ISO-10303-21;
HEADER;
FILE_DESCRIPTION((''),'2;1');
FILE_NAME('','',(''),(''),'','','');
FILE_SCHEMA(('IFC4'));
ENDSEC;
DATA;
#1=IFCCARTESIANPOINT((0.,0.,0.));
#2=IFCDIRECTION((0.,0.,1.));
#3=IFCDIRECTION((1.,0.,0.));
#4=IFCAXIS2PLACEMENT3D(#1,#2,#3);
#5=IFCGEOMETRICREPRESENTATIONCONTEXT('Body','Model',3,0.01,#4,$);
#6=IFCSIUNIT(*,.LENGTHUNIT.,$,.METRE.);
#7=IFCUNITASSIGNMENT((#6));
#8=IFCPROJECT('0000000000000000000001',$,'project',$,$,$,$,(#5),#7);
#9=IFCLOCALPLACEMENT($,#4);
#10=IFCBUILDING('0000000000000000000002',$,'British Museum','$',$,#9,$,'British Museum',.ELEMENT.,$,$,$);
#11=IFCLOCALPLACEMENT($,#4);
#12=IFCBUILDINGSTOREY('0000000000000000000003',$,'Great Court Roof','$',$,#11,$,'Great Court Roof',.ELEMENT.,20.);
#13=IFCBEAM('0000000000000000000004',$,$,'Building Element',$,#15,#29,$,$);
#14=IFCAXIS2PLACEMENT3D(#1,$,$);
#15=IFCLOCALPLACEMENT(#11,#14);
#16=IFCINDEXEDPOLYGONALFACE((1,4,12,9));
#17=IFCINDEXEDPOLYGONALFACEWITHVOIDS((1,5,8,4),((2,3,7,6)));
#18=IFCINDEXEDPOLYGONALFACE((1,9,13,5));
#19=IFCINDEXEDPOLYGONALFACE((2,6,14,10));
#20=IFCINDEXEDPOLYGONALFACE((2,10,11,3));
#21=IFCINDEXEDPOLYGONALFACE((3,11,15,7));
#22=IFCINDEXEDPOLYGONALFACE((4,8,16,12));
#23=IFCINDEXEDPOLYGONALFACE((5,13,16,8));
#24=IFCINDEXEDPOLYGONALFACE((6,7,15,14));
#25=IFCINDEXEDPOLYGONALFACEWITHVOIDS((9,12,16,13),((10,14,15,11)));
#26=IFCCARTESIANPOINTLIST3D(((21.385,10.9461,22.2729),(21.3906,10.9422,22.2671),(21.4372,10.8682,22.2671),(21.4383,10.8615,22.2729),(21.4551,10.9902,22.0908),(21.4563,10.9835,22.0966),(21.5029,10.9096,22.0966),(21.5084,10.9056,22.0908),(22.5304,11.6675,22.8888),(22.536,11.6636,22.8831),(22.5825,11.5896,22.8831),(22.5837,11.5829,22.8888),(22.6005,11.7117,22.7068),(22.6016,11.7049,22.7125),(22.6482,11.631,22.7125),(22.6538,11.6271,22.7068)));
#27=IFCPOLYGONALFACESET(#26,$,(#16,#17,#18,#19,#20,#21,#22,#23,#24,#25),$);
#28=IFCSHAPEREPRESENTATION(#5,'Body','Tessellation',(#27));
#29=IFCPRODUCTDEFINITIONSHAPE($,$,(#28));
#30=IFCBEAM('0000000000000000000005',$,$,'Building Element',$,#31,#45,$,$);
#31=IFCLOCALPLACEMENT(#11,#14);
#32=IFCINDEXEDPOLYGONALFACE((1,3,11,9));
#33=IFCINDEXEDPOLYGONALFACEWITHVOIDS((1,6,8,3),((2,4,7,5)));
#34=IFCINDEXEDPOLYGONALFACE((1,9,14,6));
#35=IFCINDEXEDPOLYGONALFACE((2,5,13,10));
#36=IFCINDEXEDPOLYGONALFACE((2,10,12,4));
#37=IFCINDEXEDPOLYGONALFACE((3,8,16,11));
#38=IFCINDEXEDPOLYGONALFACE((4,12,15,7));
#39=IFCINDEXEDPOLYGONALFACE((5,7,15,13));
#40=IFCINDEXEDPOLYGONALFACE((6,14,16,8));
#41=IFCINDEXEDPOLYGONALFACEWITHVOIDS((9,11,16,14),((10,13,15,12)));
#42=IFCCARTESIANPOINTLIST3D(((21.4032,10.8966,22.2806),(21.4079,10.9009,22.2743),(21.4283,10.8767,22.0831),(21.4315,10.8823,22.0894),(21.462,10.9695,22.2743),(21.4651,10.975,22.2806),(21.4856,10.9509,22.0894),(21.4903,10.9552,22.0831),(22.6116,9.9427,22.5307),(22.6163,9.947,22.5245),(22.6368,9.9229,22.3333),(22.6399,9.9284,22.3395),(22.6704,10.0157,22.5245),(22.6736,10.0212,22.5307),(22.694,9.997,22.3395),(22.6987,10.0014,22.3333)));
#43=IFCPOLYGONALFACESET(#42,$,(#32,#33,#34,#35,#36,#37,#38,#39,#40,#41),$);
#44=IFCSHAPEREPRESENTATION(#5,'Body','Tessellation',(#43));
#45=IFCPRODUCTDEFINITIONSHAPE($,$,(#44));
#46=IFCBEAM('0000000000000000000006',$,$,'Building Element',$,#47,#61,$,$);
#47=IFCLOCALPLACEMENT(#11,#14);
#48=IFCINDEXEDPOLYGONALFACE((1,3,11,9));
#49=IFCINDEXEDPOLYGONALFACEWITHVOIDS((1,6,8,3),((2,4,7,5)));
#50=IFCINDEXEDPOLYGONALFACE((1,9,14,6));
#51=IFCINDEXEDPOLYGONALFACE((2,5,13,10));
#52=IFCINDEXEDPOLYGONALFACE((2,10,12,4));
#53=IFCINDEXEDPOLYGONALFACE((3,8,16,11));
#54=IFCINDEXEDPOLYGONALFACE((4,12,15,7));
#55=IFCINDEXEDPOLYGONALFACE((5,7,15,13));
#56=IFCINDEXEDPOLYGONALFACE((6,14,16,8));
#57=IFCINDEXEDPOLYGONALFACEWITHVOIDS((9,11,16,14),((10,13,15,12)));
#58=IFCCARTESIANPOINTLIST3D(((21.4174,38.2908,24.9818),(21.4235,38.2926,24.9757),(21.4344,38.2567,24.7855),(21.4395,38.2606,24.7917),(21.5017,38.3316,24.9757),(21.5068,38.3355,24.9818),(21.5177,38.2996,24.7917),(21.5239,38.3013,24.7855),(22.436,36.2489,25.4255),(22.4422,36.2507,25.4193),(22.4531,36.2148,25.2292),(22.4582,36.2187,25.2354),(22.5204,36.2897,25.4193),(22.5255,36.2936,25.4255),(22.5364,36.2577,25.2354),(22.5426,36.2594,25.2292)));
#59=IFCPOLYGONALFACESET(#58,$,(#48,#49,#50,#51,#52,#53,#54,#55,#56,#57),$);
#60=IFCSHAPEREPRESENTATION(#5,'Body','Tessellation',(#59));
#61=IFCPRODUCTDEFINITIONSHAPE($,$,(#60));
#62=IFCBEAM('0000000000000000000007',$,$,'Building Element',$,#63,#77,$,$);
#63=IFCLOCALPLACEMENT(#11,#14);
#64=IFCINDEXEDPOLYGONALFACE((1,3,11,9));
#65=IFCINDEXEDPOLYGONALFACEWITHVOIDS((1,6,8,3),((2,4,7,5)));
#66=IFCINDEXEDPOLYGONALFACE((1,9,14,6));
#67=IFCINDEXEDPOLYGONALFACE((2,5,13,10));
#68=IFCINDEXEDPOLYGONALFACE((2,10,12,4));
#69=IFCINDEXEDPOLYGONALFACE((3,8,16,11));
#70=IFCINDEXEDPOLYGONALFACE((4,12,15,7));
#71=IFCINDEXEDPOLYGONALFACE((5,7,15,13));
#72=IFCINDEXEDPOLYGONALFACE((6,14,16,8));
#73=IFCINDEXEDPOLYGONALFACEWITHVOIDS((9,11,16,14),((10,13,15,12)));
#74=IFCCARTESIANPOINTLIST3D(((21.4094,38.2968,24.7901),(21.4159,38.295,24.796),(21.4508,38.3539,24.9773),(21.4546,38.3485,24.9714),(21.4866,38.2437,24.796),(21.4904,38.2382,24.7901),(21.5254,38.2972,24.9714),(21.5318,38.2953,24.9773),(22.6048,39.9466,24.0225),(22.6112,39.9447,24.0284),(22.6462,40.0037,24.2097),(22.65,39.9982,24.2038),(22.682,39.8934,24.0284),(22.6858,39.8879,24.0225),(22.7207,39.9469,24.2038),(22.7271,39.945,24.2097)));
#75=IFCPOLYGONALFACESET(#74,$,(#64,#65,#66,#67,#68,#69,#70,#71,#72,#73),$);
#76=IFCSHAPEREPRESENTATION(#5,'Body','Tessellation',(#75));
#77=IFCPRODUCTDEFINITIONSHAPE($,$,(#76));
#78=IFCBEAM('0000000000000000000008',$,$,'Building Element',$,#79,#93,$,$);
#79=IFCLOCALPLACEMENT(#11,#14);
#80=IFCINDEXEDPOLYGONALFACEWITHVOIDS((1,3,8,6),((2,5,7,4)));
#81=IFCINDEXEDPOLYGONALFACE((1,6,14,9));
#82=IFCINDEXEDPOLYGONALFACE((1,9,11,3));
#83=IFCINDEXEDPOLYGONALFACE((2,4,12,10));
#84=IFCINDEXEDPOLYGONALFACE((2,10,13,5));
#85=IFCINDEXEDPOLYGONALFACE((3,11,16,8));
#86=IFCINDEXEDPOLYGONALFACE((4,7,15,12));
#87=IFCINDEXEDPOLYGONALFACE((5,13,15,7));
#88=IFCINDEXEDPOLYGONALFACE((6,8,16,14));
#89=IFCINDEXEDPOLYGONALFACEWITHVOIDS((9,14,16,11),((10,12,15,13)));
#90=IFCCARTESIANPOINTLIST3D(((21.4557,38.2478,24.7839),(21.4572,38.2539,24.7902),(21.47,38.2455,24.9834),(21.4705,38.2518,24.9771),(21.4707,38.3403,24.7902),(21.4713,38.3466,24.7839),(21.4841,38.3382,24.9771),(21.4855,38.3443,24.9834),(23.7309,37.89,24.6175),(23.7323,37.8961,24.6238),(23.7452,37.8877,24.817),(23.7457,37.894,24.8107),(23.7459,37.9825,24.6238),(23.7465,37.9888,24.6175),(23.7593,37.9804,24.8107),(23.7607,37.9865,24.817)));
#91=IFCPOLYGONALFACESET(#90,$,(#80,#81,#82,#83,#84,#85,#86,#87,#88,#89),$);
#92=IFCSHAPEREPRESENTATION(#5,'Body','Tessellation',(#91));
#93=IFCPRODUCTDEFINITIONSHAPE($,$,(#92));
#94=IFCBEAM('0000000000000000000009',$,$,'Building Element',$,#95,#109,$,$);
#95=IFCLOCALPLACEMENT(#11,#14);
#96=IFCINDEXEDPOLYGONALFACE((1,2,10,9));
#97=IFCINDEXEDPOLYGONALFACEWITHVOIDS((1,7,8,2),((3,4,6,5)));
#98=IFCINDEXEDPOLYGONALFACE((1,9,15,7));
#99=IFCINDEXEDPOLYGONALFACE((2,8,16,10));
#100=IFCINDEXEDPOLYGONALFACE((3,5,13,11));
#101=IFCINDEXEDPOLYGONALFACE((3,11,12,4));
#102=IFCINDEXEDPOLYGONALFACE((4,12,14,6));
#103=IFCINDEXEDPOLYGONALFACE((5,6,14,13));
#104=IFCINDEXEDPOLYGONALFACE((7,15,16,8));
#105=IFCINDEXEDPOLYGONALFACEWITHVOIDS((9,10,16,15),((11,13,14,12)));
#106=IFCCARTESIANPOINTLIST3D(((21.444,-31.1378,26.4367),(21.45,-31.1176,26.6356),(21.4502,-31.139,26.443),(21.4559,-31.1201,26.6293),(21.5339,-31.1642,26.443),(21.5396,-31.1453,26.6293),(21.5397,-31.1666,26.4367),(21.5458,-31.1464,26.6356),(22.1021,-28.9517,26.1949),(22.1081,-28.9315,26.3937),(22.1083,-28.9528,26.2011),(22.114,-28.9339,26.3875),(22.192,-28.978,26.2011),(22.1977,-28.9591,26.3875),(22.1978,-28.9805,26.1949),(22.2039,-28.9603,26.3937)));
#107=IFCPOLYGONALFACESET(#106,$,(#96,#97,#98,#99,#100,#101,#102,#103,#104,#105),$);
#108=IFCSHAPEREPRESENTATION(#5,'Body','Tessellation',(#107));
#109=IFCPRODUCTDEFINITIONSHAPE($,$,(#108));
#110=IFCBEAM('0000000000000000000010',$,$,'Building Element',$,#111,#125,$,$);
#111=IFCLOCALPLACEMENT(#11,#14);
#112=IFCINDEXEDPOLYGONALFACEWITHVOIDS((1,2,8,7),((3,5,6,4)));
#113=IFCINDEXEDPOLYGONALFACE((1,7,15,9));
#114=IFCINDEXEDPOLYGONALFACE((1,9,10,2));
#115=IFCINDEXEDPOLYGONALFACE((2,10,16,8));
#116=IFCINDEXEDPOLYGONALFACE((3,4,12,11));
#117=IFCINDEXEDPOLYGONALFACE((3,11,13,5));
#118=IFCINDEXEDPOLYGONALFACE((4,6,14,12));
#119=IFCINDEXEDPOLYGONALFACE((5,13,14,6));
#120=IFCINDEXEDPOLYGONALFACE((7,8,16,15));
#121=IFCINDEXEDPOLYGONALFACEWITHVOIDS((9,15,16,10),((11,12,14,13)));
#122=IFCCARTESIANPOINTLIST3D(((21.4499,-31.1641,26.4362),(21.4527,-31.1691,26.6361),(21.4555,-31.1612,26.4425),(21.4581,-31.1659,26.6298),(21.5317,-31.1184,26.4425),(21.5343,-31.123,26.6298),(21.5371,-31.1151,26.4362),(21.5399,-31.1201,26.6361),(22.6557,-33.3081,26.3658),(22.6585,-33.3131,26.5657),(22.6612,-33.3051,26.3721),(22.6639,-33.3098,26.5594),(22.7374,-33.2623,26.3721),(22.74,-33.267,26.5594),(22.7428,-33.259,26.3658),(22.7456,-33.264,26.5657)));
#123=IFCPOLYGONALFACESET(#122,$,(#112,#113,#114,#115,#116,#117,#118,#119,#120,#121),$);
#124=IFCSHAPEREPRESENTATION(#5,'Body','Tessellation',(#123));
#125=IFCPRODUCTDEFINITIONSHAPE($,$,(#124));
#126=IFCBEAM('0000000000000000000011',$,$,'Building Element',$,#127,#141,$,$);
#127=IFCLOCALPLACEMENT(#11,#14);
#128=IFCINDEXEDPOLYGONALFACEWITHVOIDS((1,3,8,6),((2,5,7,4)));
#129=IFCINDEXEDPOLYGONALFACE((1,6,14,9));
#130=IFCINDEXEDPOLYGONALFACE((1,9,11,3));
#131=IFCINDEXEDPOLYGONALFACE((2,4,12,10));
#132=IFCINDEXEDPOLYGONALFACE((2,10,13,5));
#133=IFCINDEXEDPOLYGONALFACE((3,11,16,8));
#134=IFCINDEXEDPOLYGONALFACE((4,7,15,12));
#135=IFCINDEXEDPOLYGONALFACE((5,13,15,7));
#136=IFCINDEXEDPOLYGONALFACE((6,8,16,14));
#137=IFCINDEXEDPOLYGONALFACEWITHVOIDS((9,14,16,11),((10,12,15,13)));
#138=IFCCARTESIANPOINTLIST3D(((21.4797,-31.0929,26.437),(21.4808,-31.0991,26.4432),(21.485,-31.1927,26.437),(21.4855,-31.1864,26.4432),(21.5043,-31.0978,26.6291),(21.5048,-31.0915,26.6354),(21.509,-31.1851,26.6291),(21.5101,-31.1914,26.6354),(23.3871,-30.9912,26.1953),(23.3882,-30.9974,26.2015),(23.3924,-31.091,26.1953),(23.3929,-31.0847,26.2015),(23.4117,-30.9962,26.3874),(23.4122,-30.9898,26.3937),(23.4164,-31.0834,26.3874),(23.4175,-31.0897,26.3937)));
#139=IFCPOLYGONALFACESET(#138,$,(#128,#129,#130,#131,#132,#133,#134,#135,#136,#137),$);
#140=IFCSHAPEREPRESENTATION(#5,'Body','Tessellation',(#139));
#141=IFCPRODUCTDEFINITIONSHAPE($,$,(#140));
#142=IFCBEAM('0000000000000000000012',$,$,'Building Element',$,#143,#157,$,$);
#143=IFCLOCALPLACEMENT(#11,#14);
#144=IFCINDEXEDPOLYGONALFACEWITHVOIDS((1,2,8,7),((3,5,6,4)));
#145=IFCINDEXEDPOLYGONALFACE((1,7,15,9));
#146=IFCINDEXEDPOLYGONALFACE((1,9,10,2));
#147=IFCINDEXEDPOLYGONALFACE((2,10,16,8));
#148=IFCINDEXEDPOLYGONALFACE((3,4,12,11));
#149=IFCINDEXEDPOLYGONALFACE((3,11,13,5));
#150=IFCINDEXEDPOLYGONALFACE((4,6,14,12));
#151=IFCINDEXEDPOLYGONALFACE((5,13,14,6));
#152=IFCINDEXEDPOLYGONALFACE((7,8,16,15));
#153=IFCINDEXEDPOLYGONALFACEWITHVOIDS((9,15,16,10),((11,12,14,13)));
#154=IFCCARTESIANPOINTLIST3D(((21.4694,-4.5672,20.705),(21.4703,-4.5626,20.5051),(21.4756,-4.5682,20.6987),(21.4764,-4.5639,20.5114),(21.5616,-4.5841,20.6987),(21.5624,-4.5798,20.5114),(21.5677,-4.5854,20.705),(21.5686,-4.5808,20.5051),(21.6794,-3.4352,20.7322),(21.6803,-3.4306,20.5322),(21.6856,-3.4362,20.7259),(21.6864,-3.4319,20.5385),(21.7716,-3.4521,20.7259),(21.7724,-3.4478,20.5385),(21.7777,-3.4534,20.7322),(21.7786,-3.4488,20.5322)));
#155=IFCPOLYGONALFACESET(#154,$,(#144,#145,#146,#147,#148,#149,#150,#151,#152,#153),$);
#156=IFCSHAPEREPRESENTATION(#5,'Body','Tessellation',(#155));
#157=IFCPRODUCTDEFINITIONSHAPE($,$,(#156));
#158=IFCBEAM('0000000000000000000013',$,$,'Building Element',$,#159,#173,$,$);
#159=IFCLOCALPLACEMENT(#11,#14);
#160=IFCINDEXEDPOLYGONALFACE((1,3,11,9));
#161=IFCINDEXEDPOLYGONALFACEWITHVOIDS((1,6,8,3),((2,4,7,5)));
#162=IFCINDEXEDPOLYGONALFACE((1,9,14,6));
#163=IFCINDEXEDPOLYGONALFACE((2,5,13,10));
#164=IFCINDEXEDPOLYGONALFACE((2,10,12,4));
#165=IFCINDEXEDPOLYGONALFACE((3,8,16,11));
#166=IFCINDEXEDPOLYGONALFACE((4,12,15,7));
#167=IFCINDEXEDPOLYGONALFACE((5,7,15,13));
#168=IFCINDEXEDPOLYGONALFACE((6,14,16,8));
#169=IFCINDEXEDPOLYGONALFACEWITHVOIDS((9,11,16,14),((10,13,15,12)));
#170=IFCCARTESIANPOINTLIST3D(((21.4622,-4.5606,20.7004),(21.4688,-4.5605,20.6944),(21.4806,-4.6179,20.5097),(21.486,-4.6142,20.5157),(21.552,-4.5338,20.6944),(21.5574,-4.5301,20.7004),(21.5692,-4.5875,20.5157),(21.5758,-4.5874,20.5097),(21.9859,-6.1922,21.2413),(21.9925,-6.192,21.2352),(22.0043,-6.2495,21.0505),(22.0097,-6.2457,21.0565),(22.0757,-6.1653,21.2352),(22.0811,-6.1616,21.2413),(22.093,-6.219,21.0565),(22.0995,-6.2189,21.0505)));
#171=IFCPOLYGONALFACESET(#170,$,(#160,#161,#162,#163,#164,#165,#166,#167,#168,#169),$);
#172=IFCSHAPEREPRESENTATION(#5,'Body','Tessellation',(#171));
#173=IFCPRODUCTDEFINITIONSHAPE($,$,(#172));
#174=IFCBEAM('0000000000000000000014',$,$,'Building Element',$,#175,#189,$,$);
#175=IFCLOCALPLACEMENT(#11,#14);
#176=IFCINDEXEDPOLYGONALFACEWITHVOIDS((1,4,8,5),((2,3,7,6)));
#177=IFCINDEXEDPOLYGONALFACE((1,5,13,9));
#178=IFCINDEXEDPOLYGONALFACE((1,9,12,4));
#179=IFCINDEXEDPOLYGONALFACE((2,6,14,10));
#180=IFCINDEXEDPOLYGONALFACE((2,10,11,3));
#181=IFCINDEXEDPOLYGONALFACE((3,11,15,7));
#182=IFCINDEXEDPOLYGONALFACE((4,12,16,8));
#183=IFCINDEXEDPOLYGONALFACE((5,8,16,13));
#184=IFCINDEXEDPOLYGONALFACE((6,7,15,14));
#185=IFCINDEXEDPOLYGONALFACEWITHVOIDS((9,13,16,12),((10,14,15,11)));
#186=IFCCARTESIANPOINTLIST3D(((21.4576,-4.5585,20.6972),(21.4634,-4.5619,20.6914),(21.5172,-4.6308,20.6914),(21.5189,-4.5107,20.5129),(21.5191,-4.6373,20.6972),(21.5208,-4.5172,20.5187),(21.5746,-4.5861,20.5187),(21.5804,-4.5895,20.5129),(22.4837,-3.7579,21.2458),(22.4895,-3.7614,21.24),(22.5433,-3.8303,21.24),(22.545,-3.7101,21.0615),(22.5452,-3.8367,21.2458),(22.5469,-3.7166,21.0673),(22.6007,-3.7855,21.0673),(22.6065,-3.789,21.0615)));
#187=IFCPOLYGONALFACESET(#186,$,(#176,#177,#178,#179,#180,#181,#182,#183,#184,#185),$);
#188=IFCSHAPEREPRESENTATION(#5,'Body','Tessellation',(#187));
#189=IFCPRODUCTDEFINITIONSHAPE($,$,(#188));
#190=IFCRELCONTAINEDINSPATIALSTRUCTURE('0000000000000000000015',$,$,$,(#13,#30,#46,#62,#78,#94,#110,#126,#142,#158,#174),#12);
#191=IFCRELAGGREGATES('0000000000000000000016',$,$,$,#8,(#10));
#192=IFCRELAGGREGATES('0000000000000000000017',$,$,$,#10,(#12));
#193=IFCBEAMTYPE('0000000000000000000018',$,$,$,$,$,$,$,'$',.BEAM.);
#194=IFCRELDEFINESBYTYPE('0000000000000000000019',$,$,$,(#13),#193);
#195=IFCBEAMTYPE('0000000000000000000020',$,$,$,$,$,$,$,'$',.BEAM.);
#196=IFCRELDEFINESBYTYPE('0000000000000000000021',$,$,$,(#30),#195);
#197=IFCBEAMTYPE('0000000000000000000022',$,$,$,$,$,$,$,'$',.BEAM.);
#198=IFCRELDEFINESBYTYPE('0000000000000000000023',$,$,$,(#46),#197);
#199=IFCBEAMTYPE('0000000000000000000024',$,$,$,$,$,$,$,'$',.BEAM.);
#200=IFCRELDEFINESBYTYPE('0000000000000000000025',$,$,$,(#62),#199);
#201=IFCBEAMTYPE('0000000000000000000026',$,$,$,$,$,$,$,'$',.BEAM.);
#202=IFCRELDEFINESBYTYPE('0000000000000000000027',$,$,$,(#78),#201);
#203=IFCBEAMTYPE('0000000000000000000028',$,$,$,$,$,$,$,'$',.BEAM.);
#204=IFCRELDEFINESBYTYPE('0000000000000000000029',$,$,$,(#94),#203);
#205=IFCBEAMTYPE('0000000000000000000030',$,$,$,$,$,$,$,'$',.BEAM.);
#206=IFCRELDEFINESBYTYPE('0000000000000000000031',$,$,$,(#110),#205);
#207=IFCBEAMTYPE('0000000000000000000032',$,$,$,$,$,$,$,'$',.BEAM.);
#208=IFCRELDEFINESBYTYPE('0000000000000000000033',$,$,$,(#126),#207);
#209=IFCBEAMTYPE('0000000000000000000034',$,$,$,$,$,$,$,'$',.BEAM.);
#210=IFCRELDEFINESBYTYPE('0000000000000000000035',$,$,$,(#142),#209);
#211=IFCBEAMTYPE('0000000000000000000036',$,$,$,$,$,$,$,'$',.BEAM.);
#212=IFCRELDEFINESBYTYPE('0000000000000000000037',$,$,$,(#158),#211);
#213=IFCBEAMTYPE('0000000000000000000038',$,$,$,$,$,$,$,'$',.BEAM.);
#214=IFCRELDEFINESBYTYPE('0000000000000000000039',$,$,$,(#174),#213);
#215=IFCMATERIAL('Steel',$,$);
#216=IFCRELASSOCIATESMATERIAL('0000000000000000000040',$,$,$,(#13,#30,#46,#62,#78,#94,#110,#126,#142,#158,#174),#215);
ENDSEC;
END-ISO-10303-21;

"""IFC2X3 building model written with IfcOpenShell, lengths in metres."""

from ifc_helpers import new_model, si_unit, frame, origin_with_axes, origin_2d, place, context, project, spatial, hollow_rectangle, extrude, material, type_object, element, save


model = new_model("IFC2X3")

# Units and contexts
model_context = context("Model", 3, precision=0.01, world=origin_with_axes(), identifier="Body")
ifc_project = project(units=[si_unit("LENGTHUNIT", "METRE")], contexts=[model_context])

# Building, storey
building_placement = place(None, origin_with_axes())
building = spatial("IfcBuilding", under=ifc_project, at=building_placement, Name="British Museum", Description="$", LongName="British Museum", CompositionType="ELEMENT")
storey_placement = place(None, origin_with_axes())
storey = spatial("IfcBuildingStorey", under=building, at=storey_placement, Name="Great Court Roof", Description="$", LongName="Great Court Roof", CompositionType="ELEMENT", Elevation=20.0)

# Beams
ifc_material = material(Name="Steel")
beam_type_1 = type_object("IfcBeamType", ElementType="$", PredefinedType="BEAM")
beam_1_placement = place(None, origin_with_axes())
element("IfcBeam", 1, at=beam_1_placement, inside=storey, type_object=beam_type_1, material=ifc_material, Description="Building Element", context=model_context, shape_type="SweptSolid", body=[
    extrude(hollow_rectangle(XDim=0.1, YDim=0.2, WallThickness=0.0063, InnerFilletRadius=0.0, OuterFilletRadius=0.0, at=origin_2d()), frame((21.4467, 10.9259, 22.1818), z_axis=(0.770158, 0.485098, 0.41417), x_axis=(-0.532958, 0.846142, 0.0)), (0.0, 0.0, 1.0), 1.4872),
])
beam_type_2 = type_object("IfcBeamType", ElementType="$", PredefinedType="BEAM")
beam_2_placement = place(None, origin_with_axes())
element("IfcBeam", 2, at=beam_2_placement, inside=storey, type_object=beam_type_2, material=ifc_material, Description="Building Element", context=model_context, shape_type="SweptSolid", body=[
    extrude(hollow_rectangle(XDim=0.1, YDim=0.2, WallThickness=0.0063, InnerFilletRadius=0.0, OuterFilletRadius=0.0, at=origin_2d()), frame((21.4467, 10.9259, 22.1818), z_axis=(0.774787, -0.611543, 0.160379), x_axis=(0.619562, 0.784947, 0.0)), (0.0, 0.0, 1.0), 1.5597),
])
beam_type_3 = type_object("IfcBeamType", ElementType="$", PredefinedType="BEAM")
beam_3_placement = place(None, origin_with_axes())
element("IfcBeam", 3, at=beam_3_placement, inside=storey, type_object=beam_type_3, material=ifc_material, Description="Building Element", context=model_context, shape_type="SweptSolid", body=[
    extrude(hollow_rectangle(XDim=0.1, YDim=0.2, WallThickness=0.0063, InnerFilletRadius=0.0, OuterFilletRadius=0.0, at=origin_2d()), frame((21.4706, 38.2961, 24.8837), z_axis=(0.438217, -0.878373, 0.19086), x_axis=(0.894822, 0.446424, 0.0)), (0.0, 0.0, 1.0), 2.3246),
])
beam_type_4 = type_object("IfcBeamType", ElementType="$", PredefinedType="BEAM")
beam_4_placement = place(None, origin_with_axes())
element("IfcBeam", 4, at=beam_4_placement, inside=storey, type_object=beam_type_4, material=ifc_material, Description="Building Element", context=model_context, shape_type="SweptSolid", body=[
    extrude(hollow_rectangle(XDim=0.1, YDim=0.2, WallThickness=0.0063, InnerFilletRadius=0.0, OuterFilletRadius=0.0, at=origin_2d()), frame((21.4706, 38.2961, 24.8837), z_axis=(0.549063, 0.757775, -0.352572), x_axis=(-0.809775, 0.586741, 0.0)), (0.0, 0.0, 1.0), 2.177),
])
beam_type_5 = type_object("IfcBeamType", ElementType="$", PredefinedType="BEAM")
beam_5_placement = place(None, origin_with_axes())
element("IfcBeam", 5, at=beam_5_placement, inside=storey, type_object=beam_type_5, material=ifc_material, Description="Building Element", context=model_context, shape_type="SweptSolid", body=[
    extrude(hollow_rectangle(XDim=0.1, YDim=0.2, WallThickness=0.0063, InnerFilletRadius=0.0, OuterFilletRadius=0.0, at=origin_2d()), frame((21.4706, 38.2961, 24.8837), z_axis=(0.985289, -0.15495, -0.072081), x_axis=(0.155354, 0.987859, 0.0)), (0.0, 0.0, 1.0), 2.3092),
])
beam_type_6 = type_object("IfcBeamType", ElementType="$", PredefinedType="BEAM")
beam_6_placement = place(None, origin_with_axes())
element("IfcBeam", 6, at=beam_6_placement, inside=storey, type_object=beam_type_6, material=ifc_material, Description="Building Element", context=model_context, shape_type="SweptSolid", body=[
    extrude(hollow_rectangle(XDim=0.1, YDim=0.2, WallThickness=0.0063, InnerFilletRadius=0.0, OuterFilletRadius=0.0, at=origin_2d()), frame((21.4949, -31.1421, 26.5362), z_axis=(0.286655, 0.952224, -0.10535), x_axis=(-0.957552, 0.288259, 0.0)), (0.0, 0.0, 1.0), 2.2958),
])
beam_type_7 = type_object("IfcBeamType", ElementType="$", PredefinedType="BEAM")
beam_7_placement = place(None, origin_with_axes())
element("IfcBeam", 7, at=beam_7_placement, inside=storey, type_object=beam_type_7, material=ifc_material, Description="Building Element", context=model_context, shape_type="SweptSolid", body=[
    extrude(hollow_rectangle(XDim=0.1, YDim=0.2, WallThickness=0.0063, InnerFilletRadius=0.0, OuterFilletRadius=0.0, at=origin_2d()), frame((21.4949, -31.1421, 26.5362), z_axis=(0.489997, -0.871254, -0.028629), x_axis=(0.871611, 0.490198, 0.0)), (0.0, 0.0, 1.0), 2.4608),
])
beam_type_8 = type_object("IfcBeamType", ElementType="$", PredefinedType="BEAM")
beam_8_placement = place(None, origin_with_axes())
element("IfcBeam", 8, at=beam_8_placement, inside=storey, type_object=beam_type_8, material=ifc_material, Description="Building Element", context=model_context, shape_type="SweptSolid", body=[
    extrude(hollow_rectangle(XDim=0.1, YDim=0.2, WallThickness=0.0063, InnerFilletRadius=0.0, OuterFilletRadius=0.0, at=origin_2d()), frame((21.4949, -31.1421, 26.5362), z_axis=(0.990682, 0.052817, -0.125537), x_axis=(-0.053238, 0.998582, 0.0)), (0.0, 0.0, 1.0), 1.9253),
])
beam_type_9 = type_object("IfcBeamType", ElementType="$", PredefinedType="BEAM")
beam_9_placement = place(None, origin_with_axes())
element("IfcBeam", 9, at=beam_9_placement, inside=storey, type_object=beam_type_9, material=ifc_material, Description="Building Element", context=model_context, shape_type="SweptSolid", body=[
    extrude(hollow_rectangle(XDim=0.1, YDim=0.2, WallThickness=0.0063, InnerFilletRadius=0.0, OuterFilletRadius=0.0, at=origin_2d()), frame((21.519, -4.574, 20.6051), z_axis=(0.182351, 0.982952, 0.02355), x_axis=(-0.983224, 0.182401, 0.0)), (0.0, 0.0, 1.0), 1.1516),
])
beam_type_10 = type_object("IfcBeamType", ElementType="$", PredefinedType="BEAM")
beam_10_placement = place(None, origin_with_axes())
element("IfcBeam", 10, at=beam_10_placement, inside=storey, type_object=beam_type_10, material=ifc_material, Description="Building Element", context=model_context, shape_type="SweptSolid", body=[
    extrude(hollow_rectangle(XDim=0.1, YDim=0.2, WallThickness=0.0063, InnerFilletRadius=0.0, OuterFilletRadius=0.0, at=origin_2d()), frame((21.519, -4.574, 20.6051), z_axis=(0.29147, -0.907996, 0.300981), x_axis=(0.952146, 0.305643, 0.0)), (0.0, 0.0, 1.0), 1.7969),
])
beam_type_11 = type_object("IfcBeamType", ElementType="$", PredefinedType="BEAM")
beam_11_placement = place(None, origin_with_axes())
element("IfcBeam", 11, at=beam_11_placement, inside=storey, type_object=beam_type_11, material=ifc_material, Description="Building Element", context=model_context, shape_type="SweptSolid", body=[
    extrude(hollow_rectangle(XDim=0.1, YDim=0.2, WallThickness=0.0063, InnerFilletRadius=0.0, OuterFilletRadius=0.0, at=origin_2d()), frame((21.519, -4.574, 20.6051), z_axis=(0.726509, 0.566836, 0.388434), x_axis=(-0.615139, 0.788419, 0.0)), (0.0, 0.0, 1.0), 1.4123),
])

save(model, "model.ifc")
